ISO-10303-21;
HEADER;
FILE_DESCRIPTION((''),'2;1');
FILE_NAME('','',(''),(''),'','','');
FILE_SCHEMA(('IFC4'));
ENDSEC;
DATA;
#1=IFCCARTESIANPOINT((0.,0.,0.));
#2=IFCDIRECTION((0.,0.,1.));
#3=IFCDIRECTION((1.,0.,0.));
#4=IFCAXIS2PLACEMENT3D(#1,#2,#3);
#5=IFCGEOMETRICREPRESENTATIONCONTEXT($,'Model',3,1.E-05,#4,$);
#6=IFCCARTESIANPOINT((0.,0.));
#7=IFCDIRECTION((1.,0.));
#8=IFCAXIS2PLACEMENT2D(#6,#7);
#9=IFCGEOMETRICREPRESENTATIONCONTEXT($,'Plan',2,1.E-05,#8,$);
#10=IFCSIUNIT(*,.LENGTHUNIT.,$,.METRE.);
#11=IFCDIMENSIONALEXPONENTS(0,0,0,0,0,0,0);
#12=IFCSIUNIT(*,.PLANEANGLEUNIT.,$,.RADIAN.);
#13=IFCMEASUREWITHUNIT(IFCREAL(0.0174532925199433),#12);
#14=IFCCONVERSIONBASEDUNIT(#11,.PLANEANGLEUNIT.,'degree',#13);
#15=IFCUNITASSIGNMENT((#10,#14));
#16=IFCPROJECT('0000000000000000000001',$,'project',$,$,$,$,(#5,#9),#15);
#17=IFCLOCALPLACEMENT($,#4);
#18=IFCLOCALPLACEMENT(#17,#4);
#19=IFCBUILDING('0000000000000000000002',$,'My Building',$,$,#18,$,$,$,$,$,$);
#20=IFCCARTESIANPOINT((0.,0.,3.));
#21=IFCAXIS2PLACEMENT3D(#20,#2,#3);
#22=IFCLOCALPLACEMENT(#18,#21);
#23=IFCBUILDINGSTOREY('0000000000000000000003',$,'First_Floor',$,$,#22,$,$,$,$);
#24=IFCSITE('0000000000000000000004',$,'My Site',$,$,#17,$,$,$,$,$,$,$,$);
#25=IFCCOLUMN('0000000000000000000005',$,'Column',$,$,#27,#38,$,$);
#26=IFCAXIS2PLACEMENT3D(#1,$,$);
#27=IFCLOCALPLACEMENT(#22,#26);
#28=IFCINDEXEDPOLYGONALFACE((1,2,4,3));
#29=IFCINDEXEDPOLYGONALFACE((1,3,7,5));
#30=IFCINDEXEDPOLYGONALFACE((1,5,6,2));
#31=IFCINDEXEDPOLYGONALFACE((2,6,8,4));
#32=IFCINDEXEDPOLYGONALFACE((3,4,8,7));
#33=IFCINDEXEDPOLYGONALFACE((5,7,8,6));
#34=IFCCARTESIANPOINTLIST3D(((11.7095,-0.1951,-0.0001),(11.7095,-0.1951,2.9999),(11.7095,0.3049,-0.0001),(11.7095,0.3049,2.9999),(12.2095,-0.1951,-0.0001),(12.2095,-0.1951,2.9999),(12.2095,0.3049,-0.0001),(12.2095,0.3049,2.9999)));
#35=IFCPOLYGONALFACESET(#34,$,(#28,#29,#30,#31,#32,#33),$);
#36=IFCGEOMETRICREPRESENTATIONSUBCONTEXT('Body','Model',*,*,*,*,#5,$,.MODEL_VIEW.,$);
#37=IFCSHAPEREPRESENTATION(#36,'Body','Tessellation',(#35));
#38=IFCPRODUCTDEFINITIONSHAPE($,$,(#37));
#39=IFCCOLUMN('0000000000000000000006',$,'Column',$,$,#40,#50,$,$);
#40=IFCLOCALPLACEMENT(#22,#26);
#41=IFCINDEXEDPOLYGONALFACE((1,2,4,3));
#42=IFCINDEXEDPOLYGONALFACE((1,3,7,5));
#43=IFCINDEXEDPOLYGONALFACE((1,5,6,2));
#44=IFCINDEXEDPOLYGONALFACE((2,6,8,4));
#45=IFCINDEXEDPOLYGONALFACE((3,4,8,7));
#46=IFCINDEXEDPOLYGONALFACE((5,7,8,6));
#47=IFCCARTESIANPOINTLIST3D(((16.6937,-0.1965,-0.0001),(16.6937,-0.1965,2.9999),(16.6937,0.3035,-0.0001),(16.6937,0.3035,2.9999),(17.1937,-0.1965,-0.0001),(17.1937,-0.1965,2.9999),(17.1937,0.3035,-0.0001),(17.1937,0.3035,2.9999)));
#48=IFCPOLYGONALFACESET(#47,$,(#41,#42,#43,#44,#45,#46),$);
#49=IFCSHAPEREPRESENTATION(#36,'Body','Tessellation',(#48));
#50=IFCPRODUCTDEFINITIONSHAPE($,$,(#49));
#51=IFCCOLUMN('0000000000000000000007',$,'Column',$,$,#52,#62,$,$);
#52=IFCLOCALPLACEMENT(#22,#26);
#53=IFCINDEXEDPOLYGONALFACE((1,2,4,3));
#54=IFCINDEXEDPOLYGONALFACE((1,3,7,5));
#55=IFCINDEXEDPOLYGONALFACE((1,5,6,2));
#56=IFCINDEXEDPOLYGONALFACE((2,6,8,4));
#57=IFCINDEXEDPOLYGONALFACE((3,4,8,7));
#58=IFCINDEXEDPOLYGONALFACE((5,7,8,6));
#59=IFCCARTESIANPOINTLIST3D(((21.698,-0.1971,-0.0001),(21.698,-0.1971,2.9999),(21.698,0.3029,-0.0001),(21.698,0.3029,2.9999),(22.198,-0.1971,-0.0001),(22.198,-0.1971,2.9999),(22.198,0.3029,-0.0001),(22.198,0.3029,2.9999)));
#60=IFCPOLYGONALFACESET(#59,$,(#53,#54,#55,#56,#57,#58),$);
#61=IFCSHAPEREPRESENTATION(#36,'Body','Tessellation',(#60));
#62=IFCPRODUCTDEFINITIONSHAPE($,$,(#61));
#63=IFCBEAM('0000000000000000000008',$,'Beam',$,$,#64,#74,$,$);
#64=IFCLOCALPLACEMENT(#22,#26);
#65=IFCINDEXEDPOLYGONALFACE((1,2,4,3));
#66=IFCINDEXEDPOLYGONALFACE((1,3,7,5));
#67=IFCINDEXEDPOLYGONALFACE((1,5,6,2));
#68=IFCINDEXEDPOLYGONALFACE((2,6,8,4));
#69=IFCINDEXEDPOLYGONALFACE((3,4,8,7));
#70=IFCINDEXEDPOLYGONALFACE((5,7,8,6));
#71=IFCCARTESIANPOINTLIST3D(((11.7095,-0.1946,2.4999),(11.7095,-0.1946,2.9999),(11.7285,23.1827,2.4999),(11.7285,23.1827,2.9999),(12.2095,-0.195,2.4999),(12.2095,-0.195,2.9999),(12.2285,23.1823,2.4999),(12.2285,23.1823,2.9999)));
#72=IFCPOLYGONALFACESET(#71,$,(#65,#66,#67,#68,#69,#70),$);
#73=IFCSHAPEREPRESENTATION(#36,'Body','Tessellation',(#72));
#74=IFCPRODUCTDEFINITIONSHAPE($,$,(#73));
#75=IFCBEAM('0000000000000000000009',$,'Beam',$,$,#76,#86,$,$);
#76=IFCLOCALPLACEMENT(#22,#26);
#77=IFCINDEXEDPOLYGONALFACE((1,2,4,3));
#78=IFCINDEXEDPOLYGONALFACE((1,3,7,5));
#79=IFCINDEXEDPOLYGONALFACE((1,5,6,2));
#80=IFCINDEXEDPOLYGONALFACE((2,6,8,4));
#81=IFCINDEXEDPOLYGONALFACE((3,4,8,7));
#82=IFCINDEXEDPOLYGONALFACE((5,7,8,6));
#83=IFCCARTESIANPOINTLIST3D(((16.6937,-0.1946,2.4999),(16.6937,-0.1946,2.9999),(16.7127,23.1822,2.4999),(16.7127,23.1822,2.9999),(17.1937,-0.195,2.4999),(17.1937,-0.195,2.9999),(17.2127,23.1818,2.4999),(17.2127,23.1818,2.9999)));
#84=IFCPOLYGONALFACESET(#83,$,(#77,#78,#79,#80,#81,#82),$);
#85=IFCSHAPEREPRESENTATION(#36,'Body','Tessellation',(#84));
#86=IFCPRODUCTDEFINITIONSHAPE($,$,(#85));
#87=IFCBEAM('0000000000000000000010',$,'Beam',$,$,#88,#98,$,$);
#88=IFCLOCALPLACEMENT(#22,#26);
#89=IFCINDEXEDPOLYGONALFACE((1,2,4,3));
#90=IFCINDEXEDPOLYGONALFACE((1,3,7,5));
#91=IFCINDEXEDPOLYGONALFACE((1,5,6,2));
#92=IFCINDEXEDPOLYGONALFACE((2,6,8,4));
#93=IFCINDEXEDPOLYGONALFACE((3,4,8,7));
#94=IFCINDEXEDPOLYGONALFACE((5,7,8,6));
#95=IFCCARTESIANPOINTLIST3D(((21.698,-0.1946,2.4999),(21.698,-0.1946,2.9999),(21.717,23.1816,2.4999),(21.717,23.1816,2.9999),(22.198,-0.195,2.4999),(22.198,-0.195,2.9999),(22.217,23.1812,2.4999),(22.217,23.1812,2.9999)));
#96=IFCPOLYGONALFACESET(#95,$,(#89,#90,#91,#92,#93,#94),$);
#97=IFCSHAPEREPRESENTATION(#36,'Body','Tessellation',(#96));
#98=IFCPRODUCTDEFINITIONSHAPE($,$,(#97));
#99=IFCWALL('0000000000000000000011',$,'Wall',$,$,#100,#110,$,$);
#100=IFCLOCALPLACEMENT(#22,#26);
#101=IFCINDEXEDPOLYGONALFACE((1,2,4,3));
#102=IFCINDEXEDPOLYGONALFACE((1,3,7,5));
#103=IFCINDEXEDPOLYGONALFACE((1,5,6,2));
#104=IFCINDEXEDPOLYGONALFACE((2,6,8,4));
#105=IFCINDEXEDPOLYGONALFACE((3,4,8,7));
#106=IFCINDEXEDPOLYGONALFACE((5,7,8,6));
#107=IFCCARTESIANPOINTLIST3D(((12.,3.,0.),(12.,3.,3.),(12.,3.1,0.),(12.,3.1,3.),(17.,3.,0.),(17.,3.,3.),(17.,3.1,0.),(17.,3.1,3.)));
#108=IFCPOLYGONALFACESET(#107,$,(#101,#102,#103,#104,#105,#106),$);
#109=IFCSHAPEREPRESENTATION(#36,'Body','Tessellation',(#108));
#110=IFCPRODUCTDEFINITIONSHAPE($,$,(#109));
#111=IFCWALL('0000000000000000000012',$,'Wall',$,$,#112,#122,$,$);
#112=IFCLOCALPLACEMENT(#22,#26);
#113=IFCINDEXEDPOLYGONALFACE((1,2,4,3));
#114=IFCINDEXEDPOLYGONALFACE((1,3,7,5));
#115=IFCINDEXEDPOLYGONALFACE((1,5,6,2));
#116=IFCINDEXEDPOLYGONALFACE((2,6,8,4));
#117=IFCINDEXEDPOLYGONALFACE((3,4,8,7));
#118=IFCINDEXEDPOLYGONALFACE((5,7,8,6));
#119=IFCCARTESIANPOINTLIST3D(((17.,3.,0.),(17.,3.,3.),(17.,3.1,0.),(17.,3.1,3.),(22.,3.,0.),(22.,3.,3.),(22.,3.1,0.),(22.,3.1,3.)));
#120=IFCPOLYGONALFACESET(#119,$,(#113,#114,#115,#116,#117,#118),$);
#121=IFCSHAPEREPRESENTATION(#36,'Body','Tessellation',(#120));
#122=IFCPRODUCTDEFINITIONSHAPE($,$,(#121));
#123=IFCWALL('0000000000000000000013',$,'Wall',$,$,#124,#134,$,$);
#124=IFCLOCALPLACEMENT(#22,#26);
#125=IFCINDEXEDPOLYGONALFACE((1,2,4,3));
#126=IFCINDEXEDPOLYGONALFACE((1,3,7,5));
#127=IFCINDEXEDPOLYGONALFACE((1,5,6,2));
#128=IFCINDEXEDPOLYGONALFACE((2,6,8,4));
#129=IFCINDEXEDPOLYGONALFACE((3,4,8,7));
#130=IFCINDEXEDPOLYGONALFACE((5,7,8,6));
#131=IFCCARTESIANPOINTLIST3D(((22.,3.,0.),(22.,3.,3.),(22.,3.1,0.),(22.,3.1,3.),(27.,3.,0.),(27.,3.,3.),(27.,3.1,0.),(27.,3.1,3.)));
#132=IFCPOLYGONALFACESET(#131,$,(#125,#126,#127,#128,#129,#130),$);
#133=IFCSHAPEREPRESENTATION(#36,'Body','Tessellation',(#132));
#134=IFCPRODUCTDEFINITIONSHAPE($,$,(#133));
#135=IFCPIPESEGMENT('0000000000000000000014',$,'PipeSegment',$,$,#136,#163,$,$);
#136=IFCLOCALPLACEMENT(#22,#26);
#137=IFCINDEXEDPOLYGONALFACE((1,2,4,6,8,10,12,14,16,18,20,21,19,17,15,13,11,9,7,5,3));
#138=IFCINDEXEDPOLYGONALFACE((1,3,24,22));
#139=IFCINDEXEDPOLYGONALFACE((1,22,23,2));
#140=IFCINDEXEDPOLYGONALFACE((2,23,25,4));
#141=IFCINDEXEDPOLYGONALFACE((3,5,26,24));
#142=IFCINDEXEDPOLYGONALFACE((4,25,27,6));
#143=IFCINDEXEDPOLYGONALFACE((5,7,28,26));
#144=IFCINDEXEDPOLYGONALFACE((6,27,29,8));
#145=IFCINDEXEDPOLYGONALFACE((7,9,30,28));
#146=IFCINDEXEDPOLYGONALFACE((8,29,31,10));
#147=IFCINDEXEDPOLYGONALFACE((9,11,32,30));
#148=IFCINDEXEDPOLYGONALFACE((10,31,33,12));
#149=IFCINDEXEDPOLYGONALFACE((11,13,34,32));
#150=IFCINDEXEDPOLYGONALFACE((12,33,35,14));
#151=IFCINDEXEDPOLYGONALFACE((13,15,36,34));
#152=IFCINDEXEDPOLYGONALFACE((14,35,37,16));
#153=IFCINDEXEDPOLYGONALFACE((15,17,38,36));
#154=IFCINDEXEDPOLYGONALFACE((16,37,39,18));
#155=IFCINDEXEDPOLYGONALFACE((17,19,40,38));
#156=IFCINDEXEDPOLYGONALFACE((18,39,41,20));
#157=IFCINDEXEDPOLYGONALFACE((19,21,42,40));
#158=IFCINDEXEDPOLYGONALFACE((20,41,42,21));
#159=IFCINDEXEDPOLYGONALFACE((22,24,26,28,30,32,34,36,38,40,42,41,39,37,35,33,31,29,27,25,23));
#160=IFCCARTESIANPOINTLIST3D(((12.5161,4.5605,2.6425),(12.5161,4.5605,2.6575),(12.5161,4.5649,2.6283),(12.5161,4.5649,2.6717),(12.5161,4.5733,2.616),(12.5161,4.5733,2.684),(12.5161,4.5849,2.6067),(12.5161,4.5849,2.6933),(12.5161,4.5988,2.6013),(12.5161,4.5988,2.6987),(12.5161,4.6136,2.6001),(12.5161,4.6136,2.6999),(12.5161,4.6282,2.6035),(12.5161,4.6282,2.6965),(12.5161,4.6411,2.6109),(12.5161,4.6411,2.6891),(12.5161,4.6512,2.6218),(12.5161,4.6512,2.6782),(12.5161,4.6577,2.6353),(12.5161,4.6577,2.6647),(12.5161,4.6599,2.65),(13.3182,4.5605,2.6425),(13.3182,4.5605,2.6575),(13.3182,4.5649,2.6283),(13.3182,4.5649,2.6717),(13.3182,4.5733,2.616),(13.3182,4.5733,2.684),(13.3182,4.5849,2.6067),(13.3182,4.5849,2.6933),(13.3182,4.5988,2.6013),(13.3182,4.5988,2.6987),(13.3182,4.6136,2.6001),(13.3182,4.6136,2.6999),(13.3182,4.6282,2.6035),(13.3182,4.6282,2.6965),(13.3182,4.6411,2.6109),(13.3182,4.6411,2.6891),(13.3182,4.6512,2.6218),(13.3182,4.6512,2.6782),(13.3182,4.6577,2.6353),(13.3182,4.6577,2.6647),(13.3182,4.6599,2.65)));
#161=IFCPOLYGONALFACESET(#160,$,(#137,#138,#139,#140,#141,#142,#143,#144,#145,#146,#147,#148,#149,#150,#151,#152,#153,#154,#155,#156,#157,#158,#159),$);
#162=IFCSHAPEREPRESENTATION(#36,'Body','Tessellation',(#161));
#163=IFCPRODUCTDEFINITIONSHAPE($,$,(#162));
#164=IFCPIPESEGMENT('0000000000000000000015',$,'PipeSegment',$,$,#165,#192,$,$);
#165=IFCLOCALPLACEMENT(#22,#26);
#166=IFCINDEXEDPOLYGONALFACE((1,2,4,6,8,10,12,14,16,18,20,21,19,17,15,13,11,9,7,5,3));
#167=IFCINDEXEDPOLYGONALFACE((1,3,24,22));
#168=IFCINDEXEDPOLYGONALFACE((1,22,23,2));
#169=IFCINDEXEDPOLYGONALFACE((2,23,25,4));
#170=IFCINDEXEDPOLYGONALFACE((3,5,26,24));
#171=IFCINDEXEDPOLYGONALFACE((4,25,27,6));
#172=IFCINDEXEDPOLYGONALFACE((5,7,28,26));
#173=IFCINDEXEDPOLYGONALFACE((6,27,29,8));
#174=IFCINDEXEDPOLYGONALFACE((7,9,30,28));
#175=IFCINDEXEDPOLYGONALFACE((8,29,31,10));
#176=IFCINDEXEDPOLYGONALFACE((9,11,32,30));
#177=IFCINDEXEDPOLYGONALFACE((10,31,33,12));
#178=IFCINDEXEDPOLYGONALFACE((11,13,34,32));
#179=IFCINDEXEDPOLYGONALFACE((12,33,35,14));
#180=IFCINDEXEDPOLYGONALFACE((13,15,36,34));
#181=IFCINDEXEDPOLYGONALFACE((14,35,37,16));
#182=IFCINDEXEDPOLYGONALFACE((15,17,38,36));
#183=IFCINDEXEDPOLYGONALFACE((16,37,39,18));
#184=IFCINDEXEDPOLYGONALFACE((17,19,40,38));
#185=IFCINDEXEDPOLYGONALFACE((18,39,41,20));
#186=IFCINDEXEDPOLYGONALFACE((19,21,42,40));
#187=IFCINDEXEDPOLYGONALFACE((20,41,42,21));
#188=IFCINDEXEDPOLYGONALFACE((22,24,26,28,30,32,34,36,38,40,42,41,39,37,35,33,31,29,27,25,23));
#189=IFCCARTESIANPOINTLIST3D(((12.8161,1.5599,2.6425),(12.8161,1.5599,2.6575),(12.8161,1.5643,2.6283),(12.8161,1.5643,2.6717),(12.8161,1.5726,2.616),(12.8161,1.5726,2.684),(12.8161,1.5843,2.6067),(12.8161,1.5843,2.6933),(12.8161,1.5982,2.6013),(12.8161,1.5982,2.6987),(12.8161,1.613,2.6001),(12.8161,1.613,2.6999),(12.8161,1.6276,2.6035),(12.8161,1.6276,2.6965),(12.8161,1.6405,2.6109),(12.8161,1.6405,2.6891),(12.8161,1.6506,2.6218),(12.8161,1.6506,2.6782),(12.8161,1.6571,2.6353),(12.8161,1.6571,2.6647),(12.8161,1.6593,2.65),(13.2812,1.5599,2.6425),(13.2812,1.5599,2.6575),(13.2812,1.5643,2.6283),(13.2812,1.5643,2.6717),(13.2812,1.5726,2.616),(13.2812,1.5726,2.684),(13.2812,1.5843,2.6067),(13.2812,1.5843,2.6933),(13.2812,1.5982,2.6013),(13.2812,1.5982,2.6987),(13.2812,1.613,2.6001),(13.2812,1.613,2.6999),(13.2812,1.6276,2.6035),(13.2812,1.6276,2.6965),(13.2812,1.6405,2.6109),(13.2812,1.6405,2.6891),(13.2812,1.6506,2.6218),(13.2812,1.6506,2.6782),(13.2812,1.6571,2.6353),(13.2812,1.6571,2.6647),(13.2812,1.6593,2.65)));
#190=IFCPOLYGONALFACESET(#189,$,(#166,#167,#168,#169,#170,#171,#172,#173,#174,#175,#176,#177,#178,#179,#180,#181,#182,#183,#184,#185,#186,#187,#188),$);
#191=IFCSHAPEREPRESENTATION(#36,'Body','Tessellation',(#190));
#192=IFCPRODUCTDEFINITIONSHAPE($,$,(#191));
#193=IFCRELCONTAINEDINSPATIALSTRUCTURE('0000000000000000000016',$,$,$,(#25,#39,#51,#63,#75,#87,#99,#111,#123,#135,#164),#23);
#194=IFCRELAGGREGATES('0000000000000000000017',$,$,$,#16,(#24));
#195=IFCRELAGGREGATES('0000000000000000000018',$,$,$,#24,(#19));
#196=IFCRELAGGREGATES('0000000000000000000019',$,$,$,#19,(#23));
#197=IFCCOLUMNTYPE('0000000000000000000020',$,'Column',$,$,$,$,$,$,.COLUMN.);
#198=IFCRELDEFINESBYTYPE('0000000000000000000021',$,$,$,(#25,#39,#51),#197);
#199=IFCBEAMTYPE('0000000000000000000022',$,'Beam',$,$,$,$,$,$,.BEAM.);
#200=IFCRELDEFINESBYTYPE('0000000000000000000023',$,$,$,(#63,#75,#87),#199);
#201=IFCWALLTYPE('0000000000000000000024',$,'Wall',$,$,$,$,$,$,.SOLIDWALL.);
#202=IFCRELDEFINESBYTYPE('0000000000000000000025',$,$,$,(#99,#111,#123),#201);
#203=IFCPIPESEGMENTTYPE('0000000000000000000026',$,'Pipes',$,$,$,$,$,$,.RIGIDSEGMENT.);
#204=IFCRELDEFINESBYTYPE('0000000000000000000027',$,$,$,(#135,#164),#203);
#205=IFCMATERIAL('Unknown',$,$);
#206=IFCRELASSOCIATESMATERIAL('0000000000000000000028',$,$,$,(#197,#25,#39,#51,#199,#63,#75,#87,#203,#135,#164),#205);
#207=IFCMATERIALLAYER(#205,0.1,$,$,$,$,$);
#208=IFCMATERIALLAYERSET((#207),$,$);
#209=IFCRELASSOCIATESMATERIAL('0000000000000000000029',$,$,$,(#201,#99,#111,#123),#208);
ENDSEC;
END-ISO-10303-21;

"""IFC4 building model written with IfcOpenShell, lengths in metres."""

from ifc_helpers import new_model, entity, si_unit, converted_unit, frame, origin_with_axes, origin_2d_with_axis, place, context, subcontext, project, spatial, line, indexed_curve, rectangle, circle, outline, extrude, material, layer, layer_set, layer_usage, material_profile, profile_set, profile_usage, type_object, element, save


model = new_model("IFC4")

# Units and contexts
model_context = context("Model", 3, precision=1e-05, world=origin_with_axes())
plan_context = context("Plan", 2, precision=1e-05, world=origin_2d_with_axis())
body_context = subcontext(model_context, "Body", "Model", "MODEL_VIEW")
ifc_project = project(units=[si_unit("LENGTHUNIT", "METRE"), converted_unit("PLANEANGLEUNIT", "degree", entity("IfcReal", 0.0174532925199433), si_unit("PLANEANGLEUNIT", "RADIAN"), dimensions=[0, 0, 0, 0, 0, 0, 0])], contexts=[model_context, plan_context])

# Site, building, storey
site_placement = place(None, origin_with_axes())
site = spatial("IfcSite", under=ifc_project, at=site_placement, Name="My Site")
building_placement = place(site_placement, origin_with_axes())
building = spatial("IfcBuilding", under=site, at=building_placement, Name="My Building")
storey_placement = place(building_placement, frame((0.0, 0.0, 3.0), z_axis=(0.0, 0.0, 1.0), x_axis=(1.0, 0.0, 0.0)))
storey = spatial("IfcBuildingStorey", under=building, at=storey_placement, Name="First_Floor")

# Columns
ifc_material = material(Name="Unknown")
ifc_material_profile_1 = material_profile(ifc_material, rectangle(XDim=0.5, YDim=0.5))
ifc_profile_set_1 = profile_set([ifc_material_profile_1])
ifc_profile_usage_1 = profile_usage(ifc_profile_set_1, cardinal=5)
column_type = type_object("IfcColumnType", Name="Column", PredefinedType="COLUMN", material=ifc_profile_set_1)
column_1_placement = place(storey_placement, frame((11.9595, 0.0549, -0.0001), z_axis=(0.0, 0.0, 1.0), x_axis=(1.0, 0.0, 0.0)))
element("IfcColumn", 1, at=column_1_placement, inside=storey, type_object=column_type, material=ifc_profile_usage_1, Name="Column", context=body_context, shape_type="SweptSolid", body=[
    extrude(rectangle(XDim=0.5, YDim=0.5), origin_with_axes(), (0.0, 0.0, 1.0), 3.0),
])
ifc_profile_usage_2 = profile_usage(ifc_profile_set_1, cardinal=5)
column_2_placement = place(storey_placement, frame((16.9437, 0.0535, -0.0001), z_axis=(0.0, 0.0, 1.0), x_axis=(1.0, 0.0, 0.0)))
element("IfcColumn", 2, at=column_2_placement, inside=storey, type_object=column_type, material=ifc_profile_usage_2, Name="Column", context=body_context, shape_type="SweptSolid", body=[
    extrude(rectangle(XDim=0.5, YDim=0.5), origin_with_axes(), (0.0, 0.0, 1.0), 3.0),
])
ifc_profile_usage_3 = profile_usage(ifc_profile_set_1, cardinal=5)
column_3_placement = place(storey_placement, frame((21.948, 0.0529, -0.0001), z_axis=(0.0, 0.0, 1.0), x_axis=(1.0, 0.0, 0.0)))
element("IfcColumn", 3, at=column_3_placement, inside=storey, type_object=column_type, material=ifc_profile_usage_3, Name="Column", context=body_context, shape_type="SweptSolid", body=[
    extrude(rectangle(XDim=0.5, YDim=0.5), origin_with_axes(), (0.0, 0.0, 1.0), 3.0),
])

# Beams
ifc_material_profile_2 = material_profile(ifc_material, rectangle(XDim=0.5, YDim=0.5))
ifc_profile_set_2 = profile_set([ifc_material_profile_2])
ifc_profile_usage_4 = profile_usage(ifc_profile_set_2, cardinal=5)
beam_type = type_object("IfcBeamType", Name="Beam", PredefinedType="BEAM", material=ifc_profile_set_2)
beam_1_placement = place(storey_placement, frame((11.9595, -0.1948, 2.7499), z_axis=(0.000813, 1.0, 0.0), x_axis=(-1.0, 0.000813, 0.0)))
element("IfcBeam", 4, at=beam_1_placement, inside=storey, type_object=beam_type, material=ifc_profile_usage_4, Name="Beam", context=body_context, shape_type="SweptSolid", body=[
    extrude(rectangle(XDim=0.5, YDim=0.5), origin_with_axes(), (0.0, 0.0, 1.0), 23.3773),
])
ifc_profile_usage_5 = profile_usage(ifc_profile_set_2, cardinal=5)
beam_2_placement = place(storey_placement, frame((16.9437, -0.1948, 2.7499), z_axis=(0.000813, 1.0, 0.0), x_axis=(-1.0, 0.000813, 0.0)))
element("IfcBeam", 5, at=beam_2_placement, inside=storey, type_object=beam_type, material=ifc_profile_usage_5, Name="Beam", context=body_context, shape_type="SweptSolid", body=[
    extrude(rectangle(XDim=0.5, YDim=0.5), origin_with_axes(), (0.0, 0.0, 1.0), 23.3767),
])
ifc_profile_usage_6 = profile_usage(ifc_profile_set_2, cardinal=5)
beam_3_placement = place(storey_placement, frame((21.948, -0.1948, 2.7499), z_axis=(0.000813, 1.0, 0.0), x_axis=(-1.0, 0.000813, 0.0)))
element("IfcBeam", 6, at=beam_3_placement, inside=storey, type_object=beam_type, material=ifc_profile_usage_6, Name="Beam", context=body_context, shape_type="SweptSolid", body=[
    extrude(rectangle(XDim=0.5, YDim=0.5), origin_with_axes(), (0.0, 0.0, 1.0), 23.3762),
])

# Walls
ifc_layer = layer(ifc_material, 0.1)
ifc_layer_set = layer_set([ifc_layer])
ifc_layer_usage_1 = layer_usage(ifc_layer_set, "AXIS2", "POSITIVE", 0.0)
wall_type = type_object("IfcWallType", Name="Wall", PredefinedType="SOLIDWALL", material=ifc_layer_set)
wall_1_placement = place(storey_placement, frame((12.0, 3.0, 0.0), z_axis=(0.0, 0.0, 1.0), x_axis=(1.0, 0.0, 0.0)))
element("IfcWall", 7, at=wall_1_placement, inside=storey, type_object=wall_type, material=ifc_layer_usage_1, Name="Wall", context=body_context, shape_type="SweptSolid", body=[
    extrude(outline(indexed_curve([(0.0, 0.0), (0.0, 0.1), (5.0, 0.1), (5.0, 0.0)], segments=[line(1, 2, 3, 4, 1)])), origin_with_axes(), (0.0, 0.0, 1.0), 3.0),
])
ifc_layer_usage_2 = layer_usage(ifc_layer_set, "AXIS2", "POSITIVE", 0.0)
wall_2_placement = place(storey_placement, frame((17.0, 3.0, 0.0), z_axis=(0.0, 0.0, 1.0), x_axis=(1.0, 0.0, 0.0)))
element("IfcWall", 8, at=wall_2_placement, inside=storey, type_object=wall_type, material=ifc_layer_usage_2, Name="Wall", context=body_context, shape_type="SweptSolid", body=[
    extrude(outline(indexed_curve([(0.0, 0.0), (0.0, 0.1), (5.0, 0.1), (5.0, 0.0)], segments=[line(1, 2, 3, 4, 1)])), origin_with_axes(), (0.0, 0.0, 1.0), 3.0),
])
ifc_layer_usage_3 = layer_usage(ifc_layer_set, "AXIS2", "POSITIVE", 0.0)
wall_3_placement = place(storey_placement, frame((22.0, 3.0, 0.0), z_axis=(0.0, 0.0, 1.0), x_axis=(1.0, 0.0, 0.0)))
element("IfcWall", 9, at=wall_3_placement, inside=storey, type_object=wall_type, material=ifc_layer_usage_3, Name="Wall", context=body_context, shape_type="SweptSolid", body=[
    extrude(outline(indexed_curve([(0.0, 0.0), (0.0, 0.1), (5.0, 0.1), (5.0, 0.0)], segments=[line(1, 2, 3, 4, 1)])), origin_with_axes(), (0.0, 0.0, 1.0), 3.0),
])

# Pipe segments
ifc_material_profile_3 = material_profile(ifc_material, circle(Radius=0.05))
ifc_profile_set_3 = profile_set([ifc_material_profile_3])
ifc_profile_usage_7 = profile_usage(ifc_profile_set_3, cardinal=5)
pipe_segment_type = type_object("IfcPipeSegmentType", Name="Pipes", PredefinedType="RIGIDSEGMENT", material=ifc_profile_set_3)
pipe_segment_1_placement = place(storey_placement, frame((12.5161, 4.6099, 2.65), z_axis=(1.0, 0.0, 0.0), x_axis=(0.0, 1.0, 0.0)))
element("IfcPipeSegment", 10, at=pipe_segment_1_placement, inside=storey, type_object=pipe_segment_type, material=ifc_profile_usage_7, Name="PipeSegment", context=body_context, shape_type="SweptSolid", body=[
    extrude(circle(Radius=0.05), origin_with_axes(), (0.0, 0.0, 1.0), 0.8022),
])
ifc_profile_usage_8 = profile_usage(ifc_profile_set_3, cardinal=5)
pipe_segment_2_placement = place(storey_placement, frame((12.8161, 1.6093, 2.65), z_axis=(1.0, 0.0, 0.0), x_axis=(0.0, 1.0, 0.0)))
element("IfcPipeSegment", 11, at=pipe_segment_2_placement, inside=storey, type_object=pipe_segment_type, material=ifc_profile_usage_8, Name="PipeSegment", context=body_context, shape_type="SweptSolid", body=[
    extrude(circle(Radius=0.05), origin_with_axes(), (0.0, 0.0, 1.0), 0.4651),
])

save(model, "model.ifc")
